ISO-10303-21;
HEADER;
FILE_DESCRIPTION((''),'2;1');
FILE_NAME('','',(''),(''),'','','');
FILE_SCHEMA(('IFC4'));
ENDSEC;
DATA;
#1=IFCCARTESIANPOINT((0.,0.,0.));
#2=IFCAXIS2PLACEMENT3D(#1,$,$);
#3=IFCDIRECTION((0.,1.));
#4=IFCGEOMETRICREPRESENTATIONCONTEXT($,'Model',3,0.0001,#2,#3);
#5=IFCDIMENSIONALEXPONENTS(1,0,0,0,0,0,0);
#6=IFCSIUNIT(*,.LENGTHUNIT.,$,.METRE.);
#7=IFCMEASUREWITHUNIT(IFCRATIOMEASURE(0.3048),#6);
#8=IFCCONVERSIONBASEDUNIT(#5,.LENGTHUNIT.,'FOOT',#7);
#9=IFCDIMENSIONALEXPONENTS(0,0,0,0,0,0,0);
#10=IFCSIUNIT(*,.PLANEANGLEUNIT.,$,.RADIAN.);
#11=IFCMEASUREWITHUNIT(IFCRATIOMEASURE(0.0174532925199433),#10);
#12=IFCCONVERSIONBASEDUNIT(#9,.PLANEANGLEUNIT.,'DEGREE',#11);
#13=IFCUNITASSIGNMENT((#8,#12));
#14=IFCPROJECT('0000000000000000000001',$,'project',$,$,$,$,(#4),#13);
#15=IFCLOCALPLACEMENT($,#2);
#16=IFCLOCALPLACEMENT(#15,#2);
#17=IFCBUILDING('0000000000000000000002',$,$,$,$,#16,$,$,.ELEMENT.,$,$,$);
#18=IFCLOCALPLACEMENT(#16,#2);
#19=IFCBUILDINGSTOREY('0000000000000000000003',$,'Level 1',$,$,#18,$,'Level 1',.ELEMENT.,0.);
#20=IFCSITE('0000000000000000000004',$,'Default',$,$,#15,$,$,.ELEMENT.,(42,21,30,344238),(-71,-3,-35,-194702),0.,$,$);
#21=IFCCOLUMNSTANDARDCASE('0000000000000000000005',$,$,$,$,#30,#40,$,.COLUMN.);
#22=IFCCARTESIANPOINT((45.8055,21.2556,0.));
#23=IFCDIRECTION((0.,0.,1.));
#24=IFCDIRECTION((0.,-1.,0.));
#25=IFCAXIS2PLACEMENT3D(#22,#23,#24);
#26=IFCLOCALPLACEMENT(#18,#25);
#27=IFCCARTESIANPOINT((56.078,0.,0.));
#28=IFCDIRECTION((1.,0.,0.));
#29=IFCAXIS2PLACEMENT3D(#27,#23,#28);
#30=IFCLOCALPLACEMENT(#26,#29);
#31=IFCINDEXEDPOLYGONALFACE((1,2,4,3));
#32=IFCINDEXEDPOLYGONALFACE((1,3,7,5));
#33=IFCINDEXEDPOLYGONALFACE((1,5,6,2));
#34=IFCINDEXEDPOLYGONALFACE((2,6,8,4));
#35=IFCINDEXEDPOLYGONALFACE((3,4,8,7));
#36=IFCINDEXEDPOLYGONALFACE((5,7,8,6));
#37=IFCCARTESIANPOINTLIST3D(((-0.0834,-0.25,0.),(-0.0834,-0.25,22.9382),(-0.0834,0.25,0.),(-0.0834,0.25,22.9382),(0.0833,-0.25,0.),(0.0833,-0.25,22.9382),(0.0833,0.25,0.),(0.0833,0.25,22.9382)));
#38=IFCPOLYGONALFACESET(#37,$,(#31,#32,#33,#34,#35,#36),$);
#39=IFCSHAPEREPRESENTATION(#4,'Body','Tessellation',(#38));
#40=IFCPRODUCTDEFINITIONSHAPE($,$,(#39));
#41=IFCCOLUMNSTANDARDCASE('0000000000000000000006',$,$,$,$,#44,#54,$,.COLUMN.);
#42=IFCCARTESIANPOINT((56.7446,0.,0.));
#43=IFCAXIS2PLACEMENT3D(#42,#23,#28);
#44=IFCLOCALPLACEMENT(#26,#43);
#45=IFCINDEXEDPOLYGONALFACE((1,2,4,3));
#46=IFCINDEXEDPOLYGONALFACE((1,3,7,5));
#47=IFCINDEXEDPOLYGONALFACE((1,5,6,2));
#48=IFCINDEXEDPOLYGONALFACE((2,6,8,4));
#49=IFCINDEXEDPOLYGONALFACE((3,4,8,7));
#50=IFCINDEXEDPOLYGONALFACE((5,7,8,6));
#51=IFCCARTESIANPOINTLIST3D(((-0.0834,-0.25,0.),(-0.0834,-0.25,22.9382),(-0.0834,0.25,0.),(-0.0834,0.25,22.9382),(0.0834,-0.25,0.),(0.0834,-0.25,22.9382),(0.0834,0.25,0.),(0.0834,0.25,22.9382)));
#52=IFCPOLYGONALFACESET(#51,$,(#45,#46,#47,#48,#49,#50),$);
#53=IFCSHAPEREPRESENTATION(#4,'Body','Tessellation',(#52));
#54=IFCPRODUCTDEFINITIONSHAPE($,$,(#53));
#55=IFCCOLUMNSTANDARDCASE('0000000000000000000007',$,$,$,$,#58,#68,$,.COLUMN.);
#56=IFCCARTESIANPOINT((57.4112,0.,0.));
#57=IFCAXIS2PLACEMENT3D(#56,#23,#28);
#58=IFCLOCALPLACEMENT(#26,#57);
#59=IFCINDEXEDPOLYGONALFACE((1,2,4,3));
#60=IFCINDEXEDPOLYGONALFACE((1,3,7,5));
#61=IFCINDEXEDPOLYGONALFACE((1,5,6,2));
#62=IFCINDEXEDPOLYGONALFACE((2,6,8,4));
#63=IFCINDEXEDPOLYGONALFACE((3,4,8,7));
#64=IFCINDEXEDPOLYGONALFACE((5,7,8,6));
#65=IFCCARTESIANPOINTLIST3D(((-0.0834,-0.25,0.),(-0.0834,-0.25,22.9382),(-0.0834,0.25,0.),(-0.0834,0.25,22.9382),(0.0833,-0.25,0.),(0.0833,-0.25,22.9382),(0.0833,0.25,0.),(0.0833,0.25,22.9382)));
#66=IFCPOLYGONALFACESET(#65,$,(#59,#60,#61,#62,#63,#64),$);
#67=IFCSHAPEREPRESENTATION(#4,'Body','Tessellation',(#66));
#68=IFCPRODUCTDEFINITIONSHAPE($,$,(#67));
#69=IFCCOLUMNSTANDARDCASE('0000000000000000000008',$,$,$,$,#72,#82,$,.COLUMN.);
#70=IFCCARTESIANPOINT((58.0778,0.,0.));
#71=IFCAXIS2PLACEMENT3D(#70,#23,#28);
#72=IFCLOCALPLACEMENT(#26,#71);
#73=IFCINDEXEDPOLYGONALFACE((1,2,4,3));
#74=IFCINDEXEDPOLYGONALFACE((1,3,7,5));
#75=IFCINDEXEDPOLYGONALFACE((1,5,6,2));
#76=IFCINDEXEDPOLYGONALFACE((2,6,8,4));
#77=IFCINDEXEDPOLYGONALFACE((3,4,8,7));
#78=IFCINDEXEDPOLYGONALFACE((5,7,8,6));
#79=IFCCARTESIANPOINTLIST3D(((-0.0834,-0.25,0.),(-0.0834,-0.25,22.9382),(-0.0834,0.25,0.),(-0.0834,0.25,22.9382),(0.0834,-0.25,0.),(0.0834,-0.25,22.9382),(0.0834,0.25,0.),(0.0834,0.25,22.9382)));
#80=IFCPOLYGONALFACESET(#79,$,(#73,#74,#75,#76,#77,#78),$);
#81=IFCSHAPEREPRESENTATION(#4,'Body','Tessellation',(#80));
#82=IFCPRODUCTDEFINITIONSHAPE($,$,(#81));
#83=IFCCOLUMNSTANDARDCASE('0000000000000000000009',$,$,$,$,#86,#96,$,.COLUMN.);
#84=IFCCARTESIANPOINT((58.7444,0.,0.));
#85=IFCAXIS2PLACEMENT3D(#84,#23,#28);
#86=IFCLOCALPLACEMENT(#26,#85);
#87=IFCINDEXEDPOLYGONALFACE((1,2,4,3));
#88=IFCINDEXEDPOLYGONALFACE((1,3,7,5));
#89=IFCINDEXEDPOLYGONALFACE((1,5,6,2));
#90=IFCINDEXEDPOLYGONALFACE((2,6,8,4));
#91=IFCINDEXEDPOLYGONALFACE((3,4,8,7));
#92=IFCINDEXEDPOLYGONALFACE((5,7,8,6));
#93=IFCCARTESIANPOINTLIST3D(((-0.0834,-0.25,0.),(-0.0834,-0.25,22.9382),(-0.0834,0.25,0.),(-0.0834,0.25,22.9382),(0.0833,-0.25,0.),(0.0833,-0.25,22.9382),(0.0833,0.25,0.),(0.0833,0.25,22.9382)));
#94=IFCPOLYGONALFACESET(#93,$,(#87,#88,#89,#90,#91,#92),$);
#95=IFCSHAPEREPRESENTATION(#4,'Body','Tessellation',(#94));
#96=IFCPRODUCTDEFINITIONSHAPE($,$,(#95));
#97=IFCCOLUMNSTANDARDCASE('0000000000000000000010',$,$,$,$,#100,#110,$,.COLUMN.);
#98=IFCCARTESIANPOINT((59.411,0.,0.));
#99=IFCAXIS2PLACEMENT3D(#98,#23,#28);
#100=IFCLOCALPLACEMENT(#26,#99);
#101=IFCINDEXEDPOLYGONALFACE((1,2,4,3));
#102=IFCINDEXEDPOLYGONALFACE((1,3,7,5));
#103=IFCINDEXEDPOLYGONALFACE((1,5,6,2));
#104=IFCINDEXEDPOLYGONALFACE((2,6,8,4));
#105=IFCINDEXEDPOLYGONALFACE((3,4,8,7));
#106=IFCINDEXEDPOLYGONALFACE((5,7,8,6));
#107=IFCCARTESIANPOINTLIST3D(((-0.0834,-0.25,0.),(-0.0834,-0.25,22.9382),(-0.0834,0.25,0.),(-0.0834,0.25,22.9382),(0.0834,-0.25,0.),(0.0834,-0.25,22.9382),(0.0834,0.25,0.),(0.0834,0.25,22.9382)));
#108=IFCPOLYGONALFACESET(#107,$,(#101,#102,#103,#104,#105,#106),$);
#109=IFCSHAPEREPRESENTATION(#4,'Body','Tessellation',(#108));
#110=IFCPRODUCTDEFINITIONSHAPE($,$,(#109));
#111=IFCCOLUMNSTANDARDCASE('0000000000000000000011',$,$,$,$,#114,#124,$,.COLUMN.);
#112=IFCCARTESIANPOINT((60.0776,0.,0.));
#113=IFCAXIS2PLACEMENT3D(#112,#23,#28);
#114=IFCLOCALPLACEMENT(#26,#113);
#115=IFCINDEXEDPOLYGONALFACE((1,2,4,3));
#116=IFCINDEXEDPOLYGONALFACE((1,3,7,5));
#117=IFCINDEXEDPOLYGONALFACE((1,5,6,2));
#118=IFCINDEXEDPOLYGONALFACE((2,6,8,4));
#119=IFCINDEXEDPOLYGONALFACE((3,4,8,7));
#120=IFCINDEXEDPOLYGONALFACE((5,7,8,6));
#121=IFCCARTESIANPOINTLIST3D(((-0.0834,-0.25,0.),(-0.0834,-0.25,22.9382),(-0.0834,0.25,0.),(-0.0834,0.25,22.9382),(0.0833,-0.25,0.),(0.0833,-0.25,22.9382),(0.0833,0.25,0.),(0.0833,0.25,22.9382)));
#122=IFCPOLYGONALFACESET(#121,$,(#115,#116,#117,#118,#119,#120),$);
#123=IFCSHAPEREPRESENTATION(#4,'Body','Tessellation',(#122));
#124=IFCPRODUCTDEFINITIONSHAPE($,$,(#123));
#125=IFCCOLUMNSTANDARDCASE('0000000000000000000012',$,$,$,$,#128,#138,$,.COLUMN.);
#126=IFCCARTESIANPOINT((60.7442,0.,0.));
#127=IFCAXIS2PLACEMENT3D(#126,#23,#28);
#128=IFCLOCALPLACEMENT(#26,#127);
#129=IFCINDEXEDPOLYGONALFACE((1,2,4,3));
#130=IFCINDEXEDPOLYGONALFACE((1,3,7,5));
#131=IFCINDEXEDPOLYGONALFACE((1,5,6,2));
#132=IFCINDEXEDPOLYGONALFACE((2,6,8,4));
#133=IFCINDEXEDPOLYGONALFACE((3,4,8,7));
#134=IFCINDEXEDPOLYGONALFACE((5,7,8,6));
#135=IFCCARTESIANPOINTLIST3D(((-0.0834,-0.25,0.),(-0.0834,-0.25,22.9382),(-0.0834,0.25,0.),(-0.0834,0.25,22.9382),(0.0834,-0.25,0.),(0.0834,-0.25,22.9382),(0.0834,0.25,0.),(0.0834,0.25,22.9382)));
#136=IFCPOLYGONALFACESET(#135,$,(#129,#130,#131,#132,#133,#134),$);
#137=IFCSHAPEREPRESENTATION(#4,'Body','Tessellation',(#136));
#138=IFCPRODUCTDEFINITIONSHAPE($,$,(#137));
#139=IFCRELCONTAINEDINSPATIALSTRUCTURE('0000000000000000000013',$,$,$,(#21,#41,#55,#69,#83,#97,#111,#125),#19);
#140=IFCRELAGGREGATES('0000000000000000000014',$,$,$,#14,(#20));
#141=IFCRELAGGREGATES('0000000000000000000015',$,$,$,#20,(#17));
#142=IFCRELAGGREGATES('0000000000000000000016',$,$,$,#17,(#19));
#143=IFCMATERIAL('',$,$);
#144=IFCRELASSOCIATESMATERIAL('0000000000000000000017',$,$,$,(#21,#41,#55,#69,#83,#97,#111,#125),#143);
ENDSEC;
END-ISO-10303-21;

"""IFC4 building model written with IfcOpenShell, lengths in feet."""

from ifc_helpers import new_model, entity, si_unit, converted_unit, direction, frame, origin, place, context, project, spatial, rectangle, extrude, material, element, save


model = new_model("IFC4")

# Units and contexts
model_context = context("Model", 3, precision=0.0001, world=origin(), true_north=direction((0.0, 1.0)))
ifc_project = project(units=[converted_unit("LENGTHUNIT", "FOOT", entity("IfcRatioMeasure", 0.3048), si_unit("LENGTHUNIT", "METRE"), dimensions=[1, 0, 0, 0, 0, 0, 0]), converted_unit("PLANEANGLEUNIT", "DEGREE", entity("IfcRatioMeasure", 0.0174532925199433), si_unit("PLANEANGLEUNIT", "RADIAN"), dimensions=[0, 0, 0, 0, 0, 0, 0])], contexts=[model_context])

# Site, building, storey
site_placement = place(None, origin())
site = spatial("IfcSite", under=ifc_project, at=site_placement, Name="Default", CompositionType="ELEMENT", RefLatitude=(42, 21, 30, 344238), RefLongitude=(-71, -3, -35, -194702), RefElevation=0.0)
building_placement = place(site_placement, origin())
building = spatial("IfcBuilding", under=site, at=building_placement, CompositionType="ELEMENT")
storey_placement = place(building_placement, origin())
storey = spatial("IfcBuildingStorey", under=building, at=storey_placement, Name="Level 1", LongName="Level 1", CompositionType="ELEMENT", Elevation=0.0)

# Columns
ifc_material_1 = material(Name="")
placement = place(storey_placement, frame((45.8055, 21.2556, 0.0), z_axis=(0.0, 0.0, 1.0), x_axis=(0.0, -1.0, 0.0)))
for number, where, z_axis, x_axis in (
    (1, (56.078, 0.0, 0.0), (0.0, 0.0, 1.0), (1.0, 0.0, 0.0)),
    (2, (56.7446, 0.0, 0.0), (0.0, 0.0, 1.0), (1.0, 0.0, 0.0)),
    (3, (57.4112, 0.0, 0.0), (0.0, 0.0, 1.0), (1.0, 0.0, 0.0)),
    (4, (58.0778, 0.0, 0.0), (0.0, 0.0, 1.0), (1.0, 0.0, 0.0)),
    (5, (58.7444, 0.0, 0.0), (0.0, 0.0, 1.0), (1.0, 0.0, 0.0)),
    (6, (59.411, 0.0, 0.0), (0.0, 0.0, 1.0), (1.0, 0.0, 0.0)),
    (7, (60.0776, 0.0, 0.0), (0.0, 0.0, 1.0), (1.0, 0.0, 0.0)),
    (8, (60.7442, 0.0, 0.0), (0.0, 0.0, 1.0), (1.0, 0.0, 0.0)),
):
    element("IfcColumnStandardCase", number, at=place(placement, frame(where, z_axis=z_axis, x_axis=x_axis)), inside=storey, material=ifc_material_1, PredefinedType="COLUMN", context=model_context, shape_type="SweptSolid", body=[
        extrude(rectangle(XDim=0.1667, YDim=0.5), origin(), (0.0, 0.0, 1.0), 22.9382),
    ])

save(model, "model.ifc")
